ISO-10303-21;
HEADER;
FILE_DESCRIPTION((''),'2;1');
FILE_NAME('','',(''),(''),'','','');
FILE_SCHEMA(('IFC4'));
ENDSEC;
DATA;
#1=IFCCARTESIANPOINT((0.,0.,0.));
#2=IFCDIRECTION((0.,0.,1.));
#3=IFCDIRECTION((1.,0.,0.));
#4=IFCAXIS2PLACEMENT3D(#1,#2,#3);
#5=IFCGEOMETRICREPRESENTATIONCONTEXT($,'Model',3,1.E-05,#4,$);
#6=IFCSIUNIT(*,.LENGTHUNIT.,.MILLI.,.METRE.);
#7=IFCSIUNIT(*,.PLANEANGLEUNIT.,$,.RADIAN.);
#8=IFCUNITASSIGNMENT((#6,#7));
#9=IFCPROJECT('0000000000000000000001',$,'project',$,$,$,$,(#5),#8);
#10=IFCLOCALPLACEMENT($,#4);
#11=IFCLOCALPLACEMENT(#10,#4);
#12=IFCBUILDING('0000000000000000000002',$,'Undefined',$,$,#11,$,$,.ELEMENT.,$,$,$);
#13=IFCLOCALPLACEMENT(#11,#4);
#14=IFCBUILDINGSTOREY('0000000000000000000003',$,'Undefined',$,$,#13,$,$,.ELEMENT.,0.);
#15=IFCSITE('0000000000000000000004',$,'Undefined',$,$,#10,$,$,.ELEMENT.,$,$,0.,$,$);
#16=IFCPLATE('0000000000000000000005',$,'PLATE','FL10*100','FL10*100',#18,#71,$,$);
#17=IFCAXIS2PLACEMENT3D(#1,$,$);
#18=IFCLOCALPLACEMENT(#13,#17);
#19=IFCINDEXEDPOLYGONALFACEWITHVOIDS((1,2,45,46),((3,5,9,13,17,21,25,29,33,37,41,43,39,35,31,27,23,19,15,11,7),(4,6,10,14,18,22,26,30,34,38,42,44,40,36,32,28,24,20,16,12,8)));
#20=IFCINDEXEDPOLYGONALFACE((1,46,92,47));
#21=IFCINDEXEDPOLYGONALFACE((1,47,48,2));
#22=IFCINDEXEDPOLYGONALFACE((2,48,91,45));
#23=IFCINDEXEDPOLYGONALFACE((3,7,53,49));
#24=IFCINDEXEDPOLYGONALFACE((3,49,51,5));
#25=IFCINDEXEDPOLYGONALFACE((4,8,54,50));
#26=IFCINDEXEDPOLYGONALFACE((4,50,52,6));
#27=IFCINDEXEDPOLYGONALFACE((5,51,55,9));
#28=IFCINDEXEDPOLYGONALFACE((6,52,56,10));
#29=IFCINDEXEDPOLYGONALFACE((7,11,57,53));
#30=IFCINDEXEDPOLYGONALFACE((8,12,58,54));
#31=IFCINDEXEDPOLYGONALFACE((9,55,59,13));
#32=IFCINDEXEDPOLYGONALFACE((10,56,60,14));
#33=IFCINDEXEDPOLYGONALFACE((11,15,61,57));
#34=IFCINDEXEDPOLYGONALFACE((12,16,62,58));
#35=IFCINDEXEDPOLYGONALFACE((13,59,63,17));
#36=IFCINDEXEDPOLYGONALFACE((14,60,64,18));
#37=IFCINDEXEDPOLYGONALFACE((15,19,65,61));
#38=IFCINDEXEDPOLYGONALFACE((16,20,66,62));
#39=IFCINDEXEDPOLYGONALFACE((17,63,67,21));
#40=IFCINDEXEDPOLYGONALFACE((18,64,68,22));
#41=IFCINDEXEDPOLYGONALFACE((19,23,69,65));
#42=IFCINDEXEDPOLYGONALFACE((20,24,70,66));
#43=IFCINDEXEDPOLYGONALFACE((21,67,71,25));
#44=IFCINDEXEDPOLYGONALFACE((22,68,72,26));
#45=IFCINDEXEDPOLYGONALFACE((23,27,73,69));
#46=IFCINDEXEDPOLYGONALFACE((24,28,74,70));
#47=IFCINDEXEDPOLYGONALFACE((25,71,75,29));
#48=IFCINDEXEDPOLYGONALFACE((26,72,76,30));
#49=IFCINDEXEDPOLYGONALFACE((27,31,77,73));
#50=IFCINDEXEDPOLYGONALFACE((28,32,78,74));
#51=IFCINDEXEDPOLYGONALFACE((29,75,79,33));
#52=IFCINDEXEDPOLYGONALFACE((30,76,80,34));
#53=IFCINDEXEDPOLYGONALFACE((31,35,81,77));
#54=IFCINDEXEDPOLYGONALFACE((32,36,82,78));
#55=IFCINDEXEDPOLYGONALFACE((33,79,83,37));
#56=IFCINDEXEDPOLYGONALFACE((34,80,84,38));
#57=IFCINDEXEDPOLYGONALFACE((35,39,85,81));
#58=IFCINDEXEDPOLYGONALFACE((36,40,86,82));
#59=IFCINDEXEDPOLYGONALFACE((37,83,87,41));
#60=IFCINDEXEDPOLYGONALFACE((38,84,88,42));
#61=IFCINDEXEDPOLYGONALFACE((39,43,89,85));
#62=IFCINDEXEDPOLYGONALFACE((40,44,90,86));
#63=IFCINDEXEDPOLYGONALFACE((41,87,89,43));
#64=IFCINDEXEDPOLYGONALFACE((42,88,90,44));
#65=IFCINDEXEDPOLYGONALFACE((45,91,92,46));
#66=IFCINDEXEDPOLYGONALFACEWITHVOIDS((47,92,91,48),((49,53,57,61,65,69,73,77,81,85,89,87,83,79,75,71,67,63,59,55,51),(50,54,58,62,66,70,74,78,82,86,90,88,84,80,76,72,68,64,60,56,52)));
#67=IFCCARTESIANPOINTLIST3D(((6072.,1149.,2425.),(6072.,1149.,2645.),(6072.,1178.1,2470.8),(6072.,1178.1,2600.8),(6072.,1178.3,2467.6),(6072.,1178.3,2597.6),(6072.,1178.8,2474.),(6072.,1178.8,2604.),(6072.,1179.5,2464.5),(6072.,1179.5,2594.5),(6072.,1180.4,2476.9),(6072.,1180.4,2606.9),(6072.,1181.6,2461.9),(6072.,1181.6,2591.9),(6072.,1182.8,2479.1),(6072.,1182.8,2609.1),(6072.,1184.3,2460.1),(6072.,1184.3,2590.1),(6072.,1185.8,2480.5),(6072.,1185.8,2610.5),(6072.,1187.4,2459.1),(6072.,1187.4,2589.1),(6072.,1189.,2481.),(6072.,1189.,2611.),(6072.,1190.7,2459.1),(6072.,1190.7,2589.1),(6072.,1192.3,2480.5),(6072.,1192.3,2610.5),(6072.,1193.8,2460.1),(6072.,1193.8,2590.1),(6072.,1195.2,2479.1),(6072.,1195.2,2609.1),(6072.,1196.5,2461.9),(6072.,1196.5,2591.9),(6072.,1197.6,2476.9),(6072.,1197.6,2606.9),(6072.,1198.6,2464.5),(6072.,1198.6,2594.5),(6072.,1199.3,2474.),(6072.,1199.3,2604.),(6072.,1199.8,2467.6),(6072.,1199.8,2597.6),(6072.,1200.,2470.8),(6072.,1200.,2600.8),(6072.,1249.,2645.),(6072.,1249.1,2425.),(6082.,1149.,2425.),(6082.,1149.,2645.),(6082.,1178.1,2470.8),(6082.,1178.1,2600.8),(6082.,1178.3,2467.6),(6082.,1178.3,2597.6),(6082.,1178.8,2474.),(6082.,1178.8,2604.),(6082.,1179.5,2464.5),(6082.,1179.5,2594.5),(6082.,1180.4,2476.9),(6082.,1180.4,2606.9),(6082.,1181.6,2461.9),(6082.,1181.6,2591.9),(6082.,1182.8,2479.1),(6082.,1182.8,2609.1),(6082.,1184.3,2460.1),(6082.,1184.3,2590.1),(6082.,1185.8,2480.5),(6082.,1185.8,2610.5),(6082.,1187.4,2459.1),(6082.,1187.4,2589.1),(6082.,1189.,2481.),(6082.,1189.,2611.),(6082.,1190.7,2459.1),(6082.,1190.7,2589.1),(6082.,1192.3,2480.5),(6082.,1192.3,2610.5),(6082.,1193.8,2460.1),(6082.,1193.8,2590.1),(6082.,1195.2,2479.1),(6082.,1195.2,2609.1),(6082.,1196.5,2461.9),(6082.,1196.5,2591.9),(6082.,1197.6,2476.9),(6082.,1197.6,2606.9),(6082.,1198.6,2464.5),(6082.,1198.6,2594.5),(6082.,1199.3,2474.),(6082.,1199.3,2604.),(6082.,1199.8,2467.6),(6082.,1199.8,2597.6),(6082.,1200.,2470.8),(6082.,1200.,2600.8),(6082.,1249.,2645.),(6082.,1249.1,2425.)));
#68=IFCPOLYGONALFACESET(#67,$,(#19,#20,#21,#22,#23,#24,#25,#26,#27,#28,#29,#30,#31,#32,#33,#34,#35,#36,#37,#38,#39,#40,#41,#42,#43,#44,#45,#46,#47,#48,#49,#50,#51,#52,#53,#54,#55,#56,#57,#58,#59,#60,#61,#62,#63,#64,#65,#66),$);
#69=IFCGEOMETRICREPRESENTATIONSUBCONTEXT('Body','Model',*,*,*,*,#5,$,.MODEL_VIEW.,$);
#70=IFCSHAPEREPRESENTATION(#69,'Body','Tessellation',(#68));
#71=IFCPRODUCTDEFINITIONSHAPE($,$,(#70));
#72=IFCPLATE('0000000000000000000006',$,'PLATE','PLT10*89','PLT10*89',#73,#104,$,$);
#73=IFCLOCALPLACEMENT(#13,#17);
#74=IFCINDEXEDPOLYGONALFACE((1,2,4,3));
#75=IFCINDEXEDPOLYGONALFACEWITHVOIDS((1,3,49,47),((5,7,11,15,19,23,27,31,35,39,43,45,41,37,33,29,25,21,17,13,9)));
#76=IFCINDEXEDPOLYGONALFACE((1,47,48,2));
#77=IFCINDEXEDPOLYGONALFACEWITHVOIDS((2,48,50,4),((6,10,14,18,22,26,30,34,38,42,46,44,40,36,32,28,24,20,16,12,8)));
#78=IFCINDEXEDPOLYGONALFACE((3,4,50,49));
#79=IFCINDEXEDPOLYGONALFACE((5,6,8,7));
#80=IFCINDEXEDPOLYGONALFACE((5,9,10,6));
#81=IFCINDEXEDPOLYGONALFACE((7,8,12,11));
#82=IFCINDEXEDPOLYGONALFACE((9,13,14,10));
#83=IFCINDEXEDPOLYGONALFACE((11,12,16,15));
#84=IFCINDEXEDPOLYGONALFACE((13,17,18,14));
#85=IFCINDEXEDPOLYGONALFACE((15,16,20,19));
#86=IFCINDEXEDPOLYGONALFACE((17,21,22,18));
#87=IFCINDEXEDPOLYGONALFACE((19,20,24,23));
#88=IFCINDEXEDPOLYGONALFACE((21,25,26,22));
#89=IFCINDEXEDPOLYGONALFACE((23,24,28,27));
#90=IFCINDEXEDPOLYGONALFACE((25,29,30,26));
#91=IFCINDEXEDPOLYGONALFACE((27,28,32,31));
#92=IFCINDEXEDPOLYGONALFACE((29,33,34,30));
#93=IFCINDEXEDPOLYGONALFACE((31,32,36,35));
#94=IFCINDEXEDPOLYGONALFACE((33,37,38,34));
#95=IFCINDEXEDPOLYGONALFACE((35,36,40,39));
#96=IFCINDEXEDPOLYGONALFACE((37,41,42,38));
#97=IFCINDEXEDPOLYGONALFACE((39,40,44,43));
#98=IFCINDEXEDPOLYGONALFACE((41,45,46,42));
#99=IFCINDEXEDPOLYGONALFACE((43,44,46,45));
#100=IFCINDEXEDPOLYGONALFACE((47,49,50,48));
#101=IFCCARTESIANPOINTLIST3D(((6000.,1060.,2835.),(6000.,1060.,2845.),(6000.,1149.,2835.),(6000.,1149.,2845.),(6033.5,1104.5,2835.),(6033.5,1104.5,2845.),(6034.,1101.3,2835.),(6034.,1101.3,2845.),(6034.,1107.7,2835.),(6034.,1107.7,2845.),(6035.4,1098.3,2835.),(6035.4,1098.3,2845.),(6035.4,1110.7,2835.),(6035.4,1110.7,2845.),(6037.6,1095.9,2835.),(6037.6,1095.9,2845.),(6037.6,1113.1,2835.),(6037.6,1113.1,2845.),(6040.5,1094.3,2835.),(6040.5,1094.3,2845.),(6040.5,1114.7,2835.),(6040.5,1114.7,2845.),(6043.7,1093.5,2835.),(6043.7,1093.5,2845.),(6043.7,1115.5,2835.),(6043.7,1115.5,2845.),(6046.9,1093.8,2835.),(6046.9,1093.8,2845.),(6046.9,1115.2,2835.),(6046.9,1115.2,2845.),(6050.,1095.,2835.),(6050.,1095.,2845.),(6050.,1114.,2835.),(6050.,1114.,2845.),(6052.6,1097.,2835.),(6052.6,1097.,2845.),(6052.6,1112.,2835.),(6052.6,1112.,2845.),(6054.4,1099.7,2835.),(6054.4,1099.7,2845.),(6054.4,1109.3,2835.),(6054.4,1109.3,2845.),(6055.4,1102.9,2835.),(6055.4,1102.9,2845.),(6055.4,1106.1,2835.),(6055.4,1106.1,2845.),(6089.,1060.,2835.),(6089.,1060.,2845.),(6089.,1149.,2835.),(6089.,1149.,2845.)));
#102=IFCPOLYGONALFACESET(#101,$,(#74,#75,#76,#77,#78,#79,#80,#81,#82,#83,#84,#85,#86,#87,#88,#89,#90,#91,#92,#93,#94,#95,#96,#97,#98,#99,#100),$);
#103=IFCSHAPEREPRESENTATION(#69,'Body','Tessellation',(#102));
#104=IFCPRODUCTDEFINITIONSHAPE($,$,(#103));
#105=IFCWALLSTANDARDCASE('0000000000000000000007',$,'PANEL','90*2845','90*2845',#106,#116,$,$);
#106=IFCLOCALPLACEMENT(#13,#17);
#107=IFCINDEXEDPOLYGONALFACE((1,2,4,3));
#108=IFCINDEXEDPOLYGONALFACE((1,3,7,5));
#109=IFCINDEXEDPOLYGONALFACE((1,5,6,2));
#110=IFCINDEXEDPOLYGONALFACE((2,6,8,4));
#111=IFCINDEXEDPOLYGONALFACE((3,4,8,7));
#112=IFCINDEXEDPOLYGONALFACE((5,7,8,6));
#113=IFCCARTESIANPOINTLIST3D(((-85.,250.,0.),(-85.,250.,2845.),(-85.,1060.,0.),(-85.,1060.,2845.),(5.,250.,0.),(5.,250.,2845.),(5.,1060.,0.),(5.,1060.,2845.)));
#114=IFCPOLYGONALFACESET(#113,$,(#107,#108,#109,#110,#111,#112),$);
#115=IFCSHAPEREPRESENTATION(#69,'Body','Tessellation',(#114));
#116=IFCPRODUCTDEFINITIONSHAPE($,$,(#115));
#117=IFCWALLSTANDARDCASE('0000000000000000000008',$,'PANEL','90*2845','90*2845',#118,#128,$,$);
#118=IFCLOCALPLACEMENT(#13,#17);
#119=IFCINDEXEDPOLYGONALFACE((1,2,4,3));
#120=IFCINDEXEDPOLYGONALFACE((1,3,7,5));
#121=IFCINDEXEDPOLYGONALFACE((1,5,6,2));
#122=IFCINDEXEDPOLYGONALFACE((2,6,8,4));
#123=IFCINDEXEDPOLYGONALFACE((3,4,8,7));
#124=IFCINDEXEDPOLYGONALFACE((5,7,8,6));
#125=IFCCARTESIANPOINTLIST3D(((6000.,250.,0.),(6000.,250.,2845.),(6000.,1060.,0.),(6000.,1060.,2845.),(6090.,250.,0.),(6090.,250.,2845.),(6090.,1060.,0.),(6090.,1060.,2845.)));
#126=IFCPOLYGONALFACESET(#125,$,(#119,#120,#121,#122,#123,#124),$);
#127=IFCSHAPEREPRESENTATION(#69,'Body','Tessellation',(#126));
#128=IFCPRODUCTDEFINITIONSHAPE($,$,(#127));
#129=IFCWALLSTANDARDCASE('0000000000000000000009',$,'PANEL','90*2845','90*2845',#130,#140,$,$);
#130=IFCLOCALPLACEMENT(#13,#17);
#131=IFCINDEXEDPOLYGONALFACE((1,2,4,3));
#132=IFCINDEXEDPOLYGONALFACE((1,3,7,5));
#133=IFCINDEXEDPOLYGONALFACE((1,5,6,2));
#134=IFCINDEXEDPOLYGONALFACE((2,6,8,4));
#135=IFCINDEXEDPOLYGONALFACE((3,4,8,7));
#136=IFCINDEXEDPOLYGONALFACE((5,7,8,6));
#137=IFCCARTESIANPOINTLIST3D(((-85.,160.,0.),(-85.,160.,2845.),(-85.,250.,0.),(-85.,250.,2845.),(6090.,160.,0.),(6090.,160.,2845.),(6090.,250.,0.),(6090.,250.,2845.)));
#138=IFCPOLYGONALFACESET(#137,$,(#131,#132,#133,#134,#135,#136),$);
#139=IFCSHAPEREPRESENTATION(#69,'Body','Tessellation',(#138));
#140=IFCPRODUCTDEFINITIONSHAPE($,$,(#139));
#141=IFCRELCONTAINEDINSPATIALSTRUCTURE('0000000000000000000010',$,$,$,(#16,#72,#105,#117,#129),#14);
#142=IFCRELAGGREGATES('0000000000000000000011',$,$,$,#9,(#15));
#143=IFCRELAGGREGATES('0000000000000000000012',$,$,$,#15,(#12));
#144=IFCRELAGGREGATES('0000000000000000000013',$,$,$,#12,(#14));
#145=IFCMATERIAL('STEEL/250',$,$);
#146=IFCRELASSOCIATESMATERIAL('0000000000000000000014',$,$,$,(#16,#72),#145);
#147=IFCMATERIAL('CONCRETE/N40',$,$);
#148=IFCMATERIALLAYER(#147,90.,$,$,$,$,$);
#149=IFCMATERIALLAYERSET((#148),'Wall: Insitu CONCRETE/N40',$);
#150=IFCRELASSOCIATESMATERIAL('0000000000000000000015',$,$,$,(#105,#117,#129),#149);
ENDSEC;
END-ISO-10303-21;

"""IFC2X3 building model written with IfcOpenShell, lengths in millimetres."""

from ifc_helpers import new_model, si_unit, frame, frame_2d, origin_with_axes, origin_2d_with_axis, place, context, subcontext, project, spatial, polyline, rectangle, circle, outline, extrude, source, transform, mapped, material, layer, layer_set, layer_usage, element, save


model = new_model("IFC2X3")

# Units and contexts
model_context = context("Model", 3, precision=1e-05, world=origin_with_axes())
body_context = subcontext(model_context, "Body", "Model", "MODEL_VIEW")
ifc_project = project(units=[si_unit("LENGTHUNIT", "METRE", prefix="MILLI"), si_unit("PLANEANGLEUNIT", "RADIAN")], contexts=[model_context])

# Site, building, storey
site_placement = place(None, origin_with_axes())
site = spatial("IfcSite", under=ifc_project, at=site_placement, Name="Undefined", CompositionType="ELEMENT", RefElevation=0.0)
building_placement = place(site_placement, origin_with_axes())
building = spatial("IfcBuilding", under=site, at=building_placement, Name="Undefined", CompositionType="ELEMENT")
storey_placement = place(building_placement, origin_with_axes())
storey = spatial("IfcBuildingStorey", under=building, at=storey_placement, Name="Undefined", CompositionType="ELEMENT", Elevation=0.0)

# Shared definitions
ifc_material_1 = material(Name="STEEL/250")
shared_shape_1 = source(origin_with_axes(), body_context, "Body", "SweptSolid", [
    extrude(circle(Radius=11.0, at=origin_2d_with_axis()), frame((0.0, -10.1, 0.0), z_axis=(0.0, 1.0, 0.0), x_axis=(1.0, 0.0, 0.0)), (0.0, 0.0, 1.0), 20.3),
])

# Plate, openings
plate_1_placement = place(storey_placement, frame((6077.0, 1249.0, 2645.0), z_axis=(1.0, 0.0, 0.0), x_axis=(0.0, -1.0, 0.0)))
plate_1 = element("IfcPlate", 1, at=plate_1_placement, inside=storey, material=ifc_material_1, Name="PLATE", Description="FL10*100", ObjectType="FL10*100", context=body_context, shape_type="SweptSolid", body=[
    extrude(outline(polyline([(0.0, 0.0), (100.0, 0.0), (100.0, 220.0), (0.0, 220.0), (0.0, 0.0)])), frame((0.0, 0.0, -5.0), z_axis=(0.0, 0.0, 1.0), x_axis=(1.0, 0.0, 0.0)), (0.0, 0.0, 1.0), 10.0),
])
shared_shape_2 = source(origin_with_axes(), body_context, "Body", "SweptSolid", [
    extrude(circle(Radius=11.0, at=origin_2d_with_axis()), frame((0.0, -10.1, 0.0), z_axis=(0.0, 1.0, 0.0), x_axis=(1.0, 0.0, 0.0)), (0.0, 0.0, 1.0), 20.3),
])
opening_1_placement = place(storey_placement, frame((6082.0, 1189.0, 2600.0), z_axis=(0.0, 1.0, 0.0), x_axis=(-0.000022, 0.0, 1.0)))
element("IfcOpeningElement", 2, at=opening_1_placement, cuts=plate_1, ObjectType="Opening", context=body_context, shape_type="MappedRepresentation", body=[
    mapped(shared_shape_2, transform((0.0, 0.0, 0.0))),
])
opening_2_placement = place(storey_placement, frame((6082.0, 1189.0, 2470.0), z_axis=(0.0, 1.0, 0.0), x_axis=(-0.000022, 0.0, 1.0)))
element("IfcOpeningElement", 3, at=opening_2_placement, cuts=plate_1, ObjectType="Opening", context=body_context, shape_type="MappedRepresentation", body=[
    mapped(shared_shape_2, transform((0.0, 0.0, 0.0))),
])

# Plate, opening
plate_2_placement = place(storey_placement, frame((6089.0, 1060.0, 2840.0), z_axis=(0.0, 0.0, 1.0), x_axis=(0.0, 1.0, 0.0)))
plate_2 = element("IfcPlate", 4, at=plate_2_placement, inside=storey, material=ifc_material_1, Name="PLATE", Description="PLT10*89", ObjectType="PLT10*89", context=body_context, shape_type="SweptSolid", body=[
    extrude(outline(polyline([(0.0, 0.0), (89.0, 0.0), (89.0, 89.0), (0.0, 89.0), (0.0, 0.0)])), frame((0.0, 0.0, -5.0), z_axis=(0.0, 0.0, 1.0), x_axis=(1.0, 0.0, 0.0)), (0.0, 0.0, 1.0), 10.0),
])
opening_3_placement = place(storey_placement, frame((6044.5, 1104.5, 2845.0), z_axis=(0.0, 1.0, 0.0), x_axis=(-1.0, 0.0, 0.0)))
element("IfcOpeningElement", 5, at=opening_3_placement, cuts=plate_2, ObjectType="Opening", context=body_context, shape_type="MappedRepresentation", body=[
    mapped(shared_shape_1, transform((0.0, 0.0, 0.0))),
])

# Walls
ifc_material_2 = material(Name="CONCRETE/N40")
ifc_layer = layer(ifc_material_2, 90.0)
ifc_layer_set = layer_set([ifc_layer], Name="Wall: Insitu CONCRETE/N40")
ifc_layer_usage_1 = layer_usage(ifc_layer_set, "AXIS2", "POSITIVE", -45.0)
wall_1_placement = place(storey_placement, frame((-40.0, 250.0, 0.0), z_axis=(0.0, 0.0, 1.0), x_axis=(0.0, 1.0, 0.0)))
element("IfcWallStandardCase", 6, at=wall_1_placement, inside=storey, material=ifc_layer_usage_1, Name="PANEL", Description="90*2845", ObjectType="90*2845", context=body_context, shape_type="SweptSolid", body=[
    extrude(rectangle(XDim=810.0, YDim=90.0, at=frame_2d((0.0, 405.0), x_axis=(0.0, -1.0))), frame((0.0, 0.0, 0.0), z_axis=(0.0, 0.0, 1.0), x_axis=(0.0, -1.0, 0.0)), (0.0, 0.0, 1.0), 2845.0),
])
ifc_layer_usage_2 = layer_usage(ifc_layer_set, "AXIS2", "POSITIVE", -45.0)
wall_2_placement = place(storey_placement, frame((6045.0, 250.0, 0.0), z_axis=(0.0, 0.0, 1.0), x_axis=(0.0, 1.0, 0.0)))
element("IfcWallStandardCase", 7, at=wall_2_placement, inside=storey, material=ifc_layer_usage_2, Name="PANEL", Description="90*2845", ObjectType="90*2845", context=body_context, shape_type="SweptSolid", body=[
    extrude(rectangle(XDim=810.0, YDim=90.0, at=frame_2d((0.0, 405.0), x_axis=(0.0, -1.0))), frame((0.0, 0.0, 0.0), z_axis=(0.0, 0.0, 1.0), x_axis=(0.0, -1.0, 0.0)), (0.0, 0.0, 1.0), 2845.0),
])
ifc_layer_usage_3 = layer_usage(ifc_layer_set, "AXIS2", "POSITIVE", -45.0)
wall_3_placement = place(storey_placement, frame((-85.0, 205.0, 0.0), z_axis=(0.0, 0.0, 1.0), x_axis=(1.0, 0.0, 0.0)))
element("IfcWallStandardCase", 8, at=wall_3_placement, inside=storey, material=ifc_layer_usage_3, Name="PANEL", Description="90*2845", ObjectType="90*2845", context=body_context, shape_type="SweptSolid", body=[
    extrude(rectangle(XDim=6175.0, YDim=90.0, at=frame_2d((0.0, 3087.5), x_axis=(0.0, -1.0))), frame((0.0, 0.0, 0.0), z_axis=(0.0, 0.0, 1.0), x_axis=(0.0, -1.0, 0.0)), (0.0, 0.0, 1.0), 2845.0),
])

save(model, "model.ifc")
